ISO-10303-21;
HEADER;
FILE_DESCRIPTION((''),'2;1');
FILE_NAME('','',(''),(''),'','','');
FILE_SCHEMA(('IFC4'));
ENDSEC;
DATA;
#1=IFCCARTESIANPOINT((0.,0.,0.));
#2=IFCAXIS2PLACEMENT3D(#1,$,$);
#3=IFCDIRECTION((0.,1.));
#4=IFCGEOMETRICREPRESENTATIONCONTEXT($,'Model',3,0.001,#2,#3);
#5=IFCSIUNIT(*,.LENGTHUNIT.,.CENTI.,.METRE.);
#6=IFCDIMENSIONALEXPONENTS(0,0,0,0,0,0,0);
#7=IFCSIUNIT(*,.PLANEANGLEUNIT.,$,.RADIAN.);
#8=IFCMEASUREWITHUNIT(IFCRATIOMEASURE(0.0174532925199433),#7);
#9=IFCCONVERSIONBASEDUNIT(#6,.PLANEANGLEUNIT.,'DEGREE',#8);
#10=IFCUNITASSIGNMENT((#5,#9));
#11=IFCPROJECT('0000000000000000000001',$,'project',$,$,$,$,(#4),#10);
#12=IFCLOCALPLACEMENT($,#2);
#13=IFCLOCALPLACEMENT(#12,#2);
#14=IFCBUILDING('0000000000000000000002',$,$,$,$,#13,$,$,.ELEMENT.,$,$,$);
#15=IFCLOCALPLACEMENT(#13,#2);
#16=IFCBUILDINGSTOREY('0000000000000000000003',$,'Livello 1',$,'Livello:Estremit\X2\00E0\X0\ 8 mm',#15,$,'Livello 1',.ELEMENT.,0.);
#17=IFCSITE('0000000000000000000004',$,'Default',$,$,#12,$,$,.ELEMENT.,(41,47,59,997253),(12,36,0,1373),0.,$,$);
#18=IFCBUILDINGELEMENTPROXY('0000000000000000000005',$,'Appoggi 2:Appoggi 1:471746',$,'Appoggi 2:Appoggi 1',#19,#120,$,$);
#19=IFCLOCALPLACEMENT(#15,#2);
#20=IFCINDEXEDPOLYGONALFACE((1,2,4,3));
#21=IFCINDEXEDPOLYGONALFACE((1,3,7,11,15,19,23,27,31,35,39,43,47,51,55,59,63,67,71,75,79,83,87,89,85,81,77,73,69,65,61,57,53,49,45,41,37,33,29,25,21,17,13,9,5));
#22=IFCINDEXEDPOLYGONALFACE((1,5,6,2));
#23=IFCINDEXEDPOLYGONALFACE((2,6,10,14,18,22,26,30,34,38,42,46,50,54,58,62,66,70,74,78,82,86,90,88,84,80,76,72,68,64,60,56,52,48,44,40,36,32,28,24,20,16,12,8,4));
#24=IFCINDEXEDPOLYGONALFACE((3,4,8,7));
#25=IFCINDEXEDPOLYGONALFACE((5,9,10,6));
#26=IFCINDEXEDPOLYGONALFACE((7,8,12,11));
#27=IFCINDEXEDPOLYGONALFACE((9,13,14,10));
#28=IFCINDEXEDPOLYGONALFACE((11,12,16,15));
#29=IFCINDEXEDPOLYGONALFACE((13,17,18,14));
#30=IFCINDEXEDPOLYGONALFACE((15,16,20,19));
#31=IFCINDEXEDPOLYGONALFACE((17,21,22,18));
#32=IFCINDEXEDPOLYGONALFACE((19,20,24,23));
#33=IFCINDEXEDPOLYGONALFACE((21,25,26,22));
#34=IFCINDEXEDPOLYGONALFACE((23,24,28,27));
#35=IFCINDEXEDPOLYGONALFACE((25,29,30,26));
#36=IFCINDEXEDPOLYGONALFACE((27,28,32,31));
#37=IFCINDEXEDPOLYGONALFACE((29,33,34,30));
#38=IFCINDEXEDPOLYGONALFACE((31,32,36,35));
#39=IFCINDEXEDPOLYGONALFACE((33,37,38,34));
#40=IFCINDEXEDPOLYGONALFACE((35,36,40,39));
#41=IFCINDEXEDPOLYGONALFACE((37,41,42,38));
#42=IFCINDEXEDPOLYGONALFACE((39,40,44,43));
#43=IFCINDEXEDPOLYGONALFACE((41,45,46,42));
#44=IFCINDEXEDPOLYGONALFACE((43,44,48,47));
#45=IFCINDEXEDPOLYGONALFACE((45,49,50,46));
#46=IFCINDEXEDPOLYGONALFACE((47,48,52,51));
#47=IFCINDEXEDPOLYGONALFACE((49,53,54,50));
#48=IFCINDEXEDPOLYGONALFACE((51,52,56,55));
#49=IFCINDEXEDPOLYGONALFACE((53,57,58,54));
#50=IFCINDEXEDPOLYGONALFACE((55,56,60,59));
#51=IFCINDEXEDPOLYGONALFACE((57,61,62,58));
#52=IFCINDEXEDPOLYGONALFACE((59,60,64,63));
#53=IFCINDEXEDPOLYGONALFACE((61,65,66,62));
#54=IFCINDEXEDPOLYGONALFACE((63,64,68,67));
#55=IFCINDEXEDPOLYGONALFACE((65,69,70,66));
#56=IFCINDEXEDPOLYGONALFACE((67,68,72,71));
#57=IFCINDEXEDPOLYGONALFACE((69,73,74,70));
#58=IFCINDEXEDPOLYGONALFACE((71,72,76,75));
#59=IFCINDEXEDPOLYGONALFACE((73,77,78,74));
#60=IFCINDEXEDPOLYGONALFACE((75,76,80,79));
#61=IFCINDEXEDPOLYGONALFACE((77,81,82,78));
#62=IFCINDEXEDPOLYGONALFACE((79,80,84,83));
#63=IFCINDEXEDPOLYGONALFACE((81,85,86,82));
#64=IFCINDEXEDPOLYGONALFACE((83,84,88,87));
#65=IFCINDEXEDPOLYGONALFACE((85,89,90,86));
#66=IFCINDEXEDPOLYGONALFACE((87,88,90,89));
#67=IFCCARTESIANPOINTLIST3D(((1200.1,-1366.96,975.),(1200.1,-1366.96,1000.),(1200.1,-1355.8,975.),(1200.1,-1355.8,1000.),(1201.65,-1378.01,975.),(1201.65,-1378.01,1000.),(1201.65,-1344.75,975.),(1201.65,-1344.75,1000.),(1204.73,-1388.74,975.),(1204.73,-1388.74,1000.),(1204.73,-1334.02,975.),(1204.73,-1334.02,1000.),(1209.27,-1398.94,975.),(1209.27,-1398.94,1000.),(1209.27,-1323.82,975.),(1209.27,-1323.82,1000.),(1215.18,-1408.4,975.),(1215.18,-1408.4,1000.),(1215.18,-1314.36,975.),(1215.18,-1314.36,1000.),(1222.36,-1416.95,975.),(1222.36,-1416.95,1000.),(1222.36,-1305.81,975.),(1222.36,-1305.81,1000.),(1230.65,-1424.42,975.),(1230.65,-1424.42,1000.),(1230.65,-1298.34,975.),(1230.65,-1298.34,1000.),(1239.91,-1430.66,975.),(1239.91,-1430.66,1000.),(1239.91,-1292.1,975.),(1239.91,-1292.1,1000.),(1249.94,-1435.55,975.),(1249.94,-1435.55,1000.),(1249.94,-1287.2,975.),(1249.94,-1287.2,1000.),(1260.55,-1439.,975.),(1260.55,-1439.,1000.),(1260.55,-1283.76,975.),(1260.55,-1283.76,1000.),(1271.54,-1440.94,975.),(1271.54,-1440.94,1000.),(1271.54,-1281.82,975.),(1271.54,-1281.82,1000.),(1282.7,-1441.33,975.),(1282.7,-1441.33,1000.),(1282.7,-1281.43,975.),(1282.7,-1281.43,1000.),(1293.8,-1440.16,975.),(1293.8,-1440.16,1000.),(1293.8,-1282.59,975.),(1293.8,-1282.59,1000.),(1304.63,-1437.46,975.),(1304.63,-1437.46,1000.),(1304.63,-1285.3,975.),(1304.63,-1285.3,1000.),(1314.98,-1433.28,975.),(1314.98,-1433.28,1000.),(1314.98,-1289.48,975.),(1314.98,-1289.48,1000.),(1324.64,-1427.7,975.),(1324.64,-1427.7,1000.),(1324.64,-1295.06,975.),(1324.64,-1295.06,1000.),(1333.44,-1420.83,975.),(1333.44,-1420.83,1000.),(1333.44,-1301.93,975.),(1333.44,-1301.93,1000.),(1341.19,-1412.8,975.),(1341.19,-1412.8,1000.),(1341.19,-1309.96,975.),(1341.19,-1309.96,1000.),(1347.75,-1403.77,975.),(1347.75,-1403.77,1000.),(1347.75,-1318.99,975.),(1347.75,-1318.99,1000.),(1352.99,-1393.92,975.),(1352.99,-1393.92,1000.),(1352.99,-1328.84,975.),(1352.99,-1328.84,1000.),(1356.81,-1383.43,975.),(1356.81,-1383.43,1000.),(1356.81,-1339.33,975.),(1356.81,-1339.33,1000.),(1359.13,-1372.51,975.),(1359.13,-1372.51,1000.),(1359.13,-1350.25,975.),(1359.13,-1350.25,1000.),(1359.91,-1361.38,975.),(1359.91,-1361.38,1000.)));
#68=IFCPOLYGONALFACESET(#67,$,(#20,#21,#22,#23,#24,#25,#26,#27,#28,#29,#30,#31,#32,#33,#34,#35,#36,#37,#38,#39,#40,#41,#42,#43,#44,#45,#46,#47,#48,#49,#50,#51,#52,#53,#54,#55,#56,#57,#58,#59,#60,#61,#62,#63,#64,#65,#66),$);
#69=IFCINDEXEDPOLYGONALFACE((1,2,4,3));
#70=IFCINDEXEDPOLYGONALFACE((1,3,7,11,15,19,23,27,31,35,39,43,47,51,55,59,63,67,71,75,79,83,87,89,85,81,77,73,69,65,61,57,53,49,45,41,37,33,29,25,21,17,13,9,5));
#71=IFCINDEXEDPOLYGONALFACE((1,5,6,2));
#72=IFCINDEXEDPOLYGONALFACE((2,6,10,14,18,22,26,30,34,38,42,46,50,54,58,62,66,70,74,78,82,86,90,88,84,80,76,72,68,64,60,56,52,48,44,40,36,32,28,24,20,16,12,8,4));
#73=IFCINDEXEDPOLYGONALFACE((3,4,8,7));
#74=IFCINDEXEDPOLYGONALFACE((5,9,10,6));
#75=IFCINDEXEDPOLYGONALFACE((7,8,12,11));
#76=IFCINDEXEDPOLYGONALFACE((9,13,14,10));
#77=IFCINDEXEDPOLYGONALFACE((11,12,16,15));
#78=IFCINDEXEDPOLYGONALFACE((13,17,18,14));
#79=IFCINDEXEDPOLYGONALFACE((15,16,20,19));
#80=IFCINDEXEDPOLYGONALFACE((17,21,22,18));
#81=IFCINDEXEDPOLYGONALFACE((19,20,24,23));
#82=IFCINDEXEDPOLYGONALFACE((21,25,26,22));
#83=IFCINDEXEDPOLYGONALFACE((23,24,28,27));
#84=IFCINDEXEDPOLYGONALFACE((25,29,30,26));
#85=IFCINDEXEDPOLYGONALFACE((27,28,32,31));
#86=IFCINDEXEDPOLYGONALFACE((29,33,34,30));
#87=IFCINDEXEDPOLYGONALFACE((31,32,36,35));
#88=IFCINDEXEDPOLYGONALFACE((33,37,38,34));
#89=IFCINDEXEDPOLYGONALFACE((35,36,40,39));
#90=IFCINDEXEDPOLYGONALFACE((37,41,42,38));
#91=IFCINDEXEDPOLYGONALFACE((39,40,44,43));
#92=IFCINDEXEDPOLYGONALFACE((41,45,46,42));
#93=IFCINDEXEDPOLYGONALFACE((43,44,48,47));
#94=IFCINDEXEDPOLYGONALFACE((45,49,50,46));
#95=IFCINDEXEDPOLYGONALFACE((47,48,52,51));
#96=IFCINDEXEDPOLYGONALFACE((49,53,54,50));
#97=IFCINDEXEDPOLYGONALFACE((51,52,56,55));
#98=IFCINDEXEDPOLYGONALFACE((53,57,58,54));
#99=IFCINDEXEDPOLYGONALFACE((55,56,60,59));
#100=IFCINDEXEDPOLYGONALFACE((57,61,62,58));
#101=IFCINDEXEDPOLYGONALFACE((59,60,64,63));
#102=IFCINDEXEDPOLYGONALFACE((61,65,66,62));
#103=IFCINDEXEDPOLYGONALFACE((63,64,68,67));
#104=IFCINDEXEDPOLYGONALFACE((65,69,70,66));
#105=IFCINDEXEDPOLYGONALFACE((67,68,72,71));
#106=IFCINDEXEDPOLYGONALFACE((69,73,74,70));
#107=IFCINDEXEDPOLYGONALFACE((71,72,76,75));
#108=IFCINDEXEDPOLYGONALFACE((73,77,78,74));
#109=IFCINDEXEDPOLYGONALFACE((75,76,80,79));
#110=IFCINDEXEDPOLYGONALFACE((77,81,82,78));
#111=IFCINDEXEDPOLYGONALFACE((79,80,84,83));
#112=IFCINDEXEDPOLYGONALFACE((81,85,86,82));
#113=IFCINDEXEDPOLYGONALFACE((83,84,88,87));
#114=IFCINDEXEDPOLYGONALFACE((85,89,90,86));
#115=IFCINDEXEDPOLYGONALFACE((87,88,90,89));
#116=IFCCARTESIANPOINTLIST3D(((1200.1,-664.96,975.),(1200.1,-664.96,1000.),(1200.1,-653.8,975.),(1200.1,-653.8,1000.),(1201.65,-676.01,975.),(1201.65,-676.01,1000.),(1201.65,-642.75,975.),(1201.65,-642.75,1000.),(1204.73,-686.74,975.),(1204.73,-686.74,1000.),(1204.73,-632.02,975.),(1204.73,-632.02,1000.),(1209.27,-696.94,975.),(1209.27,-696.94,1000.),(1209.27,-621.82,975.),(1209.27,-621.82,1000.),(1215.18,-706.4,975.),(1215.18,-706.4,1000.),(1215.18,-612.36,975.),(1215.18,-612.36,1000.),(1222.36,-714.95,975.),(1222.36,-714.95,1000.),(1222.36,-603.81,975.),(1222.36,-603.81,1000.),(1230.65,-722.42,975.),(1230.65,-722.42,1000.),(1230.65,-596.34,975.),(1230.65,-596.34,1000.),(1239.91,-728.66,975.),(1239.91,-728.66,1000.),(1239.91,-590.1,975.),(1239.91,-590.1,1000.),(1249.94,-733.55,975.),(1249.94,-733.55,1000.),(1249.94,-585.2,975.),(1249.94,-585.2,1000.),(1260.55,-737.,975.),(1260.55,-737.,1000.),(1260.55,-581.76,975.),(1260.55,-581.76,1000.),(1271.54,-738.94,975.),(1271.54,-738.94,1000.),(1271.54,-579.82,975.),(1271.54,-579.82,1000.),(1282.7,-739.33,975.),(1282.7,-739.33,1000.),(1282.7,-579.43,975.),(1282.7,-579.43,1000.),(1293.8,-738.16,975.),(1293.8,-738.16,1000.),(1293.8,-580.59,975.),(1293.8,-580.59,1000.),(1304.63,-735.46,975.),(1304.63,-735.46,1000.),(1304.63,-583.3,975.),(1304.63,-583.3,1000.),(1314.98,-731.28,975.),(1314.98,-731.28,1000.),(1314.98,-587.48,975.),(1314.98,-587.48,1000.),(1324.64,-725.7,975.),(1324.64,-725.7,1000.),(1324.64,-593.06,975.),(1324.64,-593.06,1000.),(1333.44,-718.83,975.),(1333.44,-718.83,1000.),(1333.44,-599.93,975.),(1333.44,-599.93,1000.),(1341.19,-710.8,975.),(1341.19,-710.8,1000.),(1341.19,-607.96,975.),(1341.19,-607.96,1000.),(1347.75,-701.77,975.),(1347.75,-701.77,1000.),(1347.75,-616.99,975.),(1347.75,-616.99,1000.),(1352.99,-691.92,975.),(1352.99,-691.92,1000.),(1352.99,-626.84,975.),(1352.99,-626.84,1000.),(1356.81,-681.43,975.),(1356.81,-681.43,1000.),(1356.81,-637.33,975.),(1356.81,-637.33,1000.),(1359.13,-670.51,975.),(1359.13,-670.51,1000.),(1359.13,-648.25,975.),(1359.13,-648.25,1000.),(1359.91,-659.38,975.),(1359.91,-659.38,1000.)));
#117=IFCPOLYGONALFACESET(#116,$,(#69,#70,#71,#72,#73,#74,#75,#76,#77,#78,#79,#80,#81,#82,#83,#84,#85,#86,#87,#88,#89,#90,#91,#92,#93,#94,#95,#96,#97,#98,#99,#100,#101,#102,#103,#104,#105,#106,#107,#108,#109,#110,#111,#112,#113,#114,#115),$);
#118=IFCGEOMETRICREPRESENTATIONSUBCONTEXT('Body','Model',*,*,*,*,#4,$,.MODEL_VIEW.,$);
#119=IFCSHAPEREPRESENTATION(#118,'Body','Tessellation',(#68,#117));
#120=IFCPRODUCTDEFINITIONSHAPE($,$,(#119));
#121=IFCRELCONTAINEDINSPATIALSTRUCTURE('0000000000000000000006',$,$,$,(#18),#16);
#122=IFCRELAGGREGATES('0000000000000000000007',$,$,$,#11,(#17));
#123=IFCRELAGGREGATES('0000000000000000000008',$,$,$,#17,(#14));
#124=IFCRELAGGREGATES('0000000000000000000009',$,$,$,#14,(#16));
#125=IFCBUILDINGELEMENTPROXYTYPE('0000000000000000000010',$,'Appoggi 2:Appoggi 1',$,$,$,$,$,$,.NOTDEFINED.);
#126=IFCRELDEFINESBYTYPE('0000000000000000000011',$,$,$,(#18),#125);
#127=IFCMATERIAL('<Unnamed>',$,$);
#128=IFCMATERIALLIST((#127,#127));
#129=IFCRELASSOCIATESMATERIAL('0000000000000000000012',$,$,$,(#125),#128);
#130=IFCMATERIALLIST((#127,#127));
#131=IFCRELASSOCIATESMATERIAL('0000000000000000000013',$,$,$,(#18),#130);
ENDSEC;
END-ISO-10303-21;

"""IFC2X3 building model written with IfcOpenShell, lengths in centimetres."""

from ifc_helpers import new_model, entity, si_unit, converted_unit, direction, frame, frame_2d, origin, place, context, subcontext, project, spatial, circle, extrude, source, transform, mapped, material, material_list, type_object, type_shapes, element, save


model = new_model("IFC2X3")

# Units and contexts
model_context = context("Model", 3, precision=0.001, world=origin(), true_north=direction((0.0, 1.0)))
body_context = subcontext(model_context, "Body", "Model", "MODEL_VIEW")
ifc_project = project(units=[si_unit("LENGTHUNIT", "METRE", prefix="CENTI"), converted_unit("PLANEANGLEUNIT", "DEGREE", entity("IfcRatioMeasure", 0.0174532925199433), si_unit("PLANEANGLEUNIT", "RADIAN"), dimensions=[0, 0, 0, 0, 0, 0, 0])], contexts=[model_context])

# Site, building, storey
site_placement = place(None, origin())
site = spatial("IfcSite", under=ifc_project, at=site_placement, Name="Default", CompositionType="ELEMENT", RefLatitude=(41, 47, 59, 997253), RefLongitude=(12, 36, 0, 1373), RefElevation=0.0)
building_placement = place(site_placement, origin())
building = spatial("IfcBuilding", under=site, at=building_placement, CompositionType="ELEMENT")
storey_placement = place(building_placement, origin())
storey = spatial("IfcBuildingStorey", under=building, at=storey_placement, Name="Livello 1", ObjectType="Livello:Estremità 8 mm", LongName="Livello 1", CompositionType="ELEMENT", Elevation=0.0)

# Shared definitions
ifc_material = material(Name="<Unnamed>")

# Building element proxy
ifc_material_list_1 = material_list([ifc_material, ifc_material])
ifc_material_list_2 = material_list([ifc_material, ifc_material])
building_element_proxy_type_1 = type_object("IfcBuildingElementProxyType", Name="Appoggi 2:Appoggi 1", PredefinedType="NOTDEFINED", material=ifc_material_list_2)
shared_shape_1 = source(origin(), body_context, "Body", "SweptSolid", [
    extrude(circle(Radius=80.0, at=frame_2d((0.0, 0.0), x_axis=(1.0, 0.0))), frame((1279.91, -1361.38, 975.0)), (0.0, 0.0, 1.0), 25.0),
    extrude(circle(Radius=80.0, at=frame_2d((0.0, 0.0), x_axis=(1.0, 0.0))), frame((1279.91, -659.38, 975.0)), (0.0, 0.0, 1.0), 25.0),
])
type_shapes(building_element_proxy_type_1, [shared_shape_1])
proxy_1_placement = place(storey_placement, origin())
element("IfcBuildingElementProxy", 1, at=proxy_1_placement, inside=storey, type_object=building_element_proxy_type_1, material=ifc_material_list_1, Name="Appoggi 2:Appoggi 1:471746", ObjectType="Appoggi 2:Appoggi 1", context=body_context, shape_type="MappedRepresentation", body=[
    mapped(shared_shape_1, transform((0.0, 0.0, 0.0), scale=1.0)),
])

save(model, "model.ifc")
